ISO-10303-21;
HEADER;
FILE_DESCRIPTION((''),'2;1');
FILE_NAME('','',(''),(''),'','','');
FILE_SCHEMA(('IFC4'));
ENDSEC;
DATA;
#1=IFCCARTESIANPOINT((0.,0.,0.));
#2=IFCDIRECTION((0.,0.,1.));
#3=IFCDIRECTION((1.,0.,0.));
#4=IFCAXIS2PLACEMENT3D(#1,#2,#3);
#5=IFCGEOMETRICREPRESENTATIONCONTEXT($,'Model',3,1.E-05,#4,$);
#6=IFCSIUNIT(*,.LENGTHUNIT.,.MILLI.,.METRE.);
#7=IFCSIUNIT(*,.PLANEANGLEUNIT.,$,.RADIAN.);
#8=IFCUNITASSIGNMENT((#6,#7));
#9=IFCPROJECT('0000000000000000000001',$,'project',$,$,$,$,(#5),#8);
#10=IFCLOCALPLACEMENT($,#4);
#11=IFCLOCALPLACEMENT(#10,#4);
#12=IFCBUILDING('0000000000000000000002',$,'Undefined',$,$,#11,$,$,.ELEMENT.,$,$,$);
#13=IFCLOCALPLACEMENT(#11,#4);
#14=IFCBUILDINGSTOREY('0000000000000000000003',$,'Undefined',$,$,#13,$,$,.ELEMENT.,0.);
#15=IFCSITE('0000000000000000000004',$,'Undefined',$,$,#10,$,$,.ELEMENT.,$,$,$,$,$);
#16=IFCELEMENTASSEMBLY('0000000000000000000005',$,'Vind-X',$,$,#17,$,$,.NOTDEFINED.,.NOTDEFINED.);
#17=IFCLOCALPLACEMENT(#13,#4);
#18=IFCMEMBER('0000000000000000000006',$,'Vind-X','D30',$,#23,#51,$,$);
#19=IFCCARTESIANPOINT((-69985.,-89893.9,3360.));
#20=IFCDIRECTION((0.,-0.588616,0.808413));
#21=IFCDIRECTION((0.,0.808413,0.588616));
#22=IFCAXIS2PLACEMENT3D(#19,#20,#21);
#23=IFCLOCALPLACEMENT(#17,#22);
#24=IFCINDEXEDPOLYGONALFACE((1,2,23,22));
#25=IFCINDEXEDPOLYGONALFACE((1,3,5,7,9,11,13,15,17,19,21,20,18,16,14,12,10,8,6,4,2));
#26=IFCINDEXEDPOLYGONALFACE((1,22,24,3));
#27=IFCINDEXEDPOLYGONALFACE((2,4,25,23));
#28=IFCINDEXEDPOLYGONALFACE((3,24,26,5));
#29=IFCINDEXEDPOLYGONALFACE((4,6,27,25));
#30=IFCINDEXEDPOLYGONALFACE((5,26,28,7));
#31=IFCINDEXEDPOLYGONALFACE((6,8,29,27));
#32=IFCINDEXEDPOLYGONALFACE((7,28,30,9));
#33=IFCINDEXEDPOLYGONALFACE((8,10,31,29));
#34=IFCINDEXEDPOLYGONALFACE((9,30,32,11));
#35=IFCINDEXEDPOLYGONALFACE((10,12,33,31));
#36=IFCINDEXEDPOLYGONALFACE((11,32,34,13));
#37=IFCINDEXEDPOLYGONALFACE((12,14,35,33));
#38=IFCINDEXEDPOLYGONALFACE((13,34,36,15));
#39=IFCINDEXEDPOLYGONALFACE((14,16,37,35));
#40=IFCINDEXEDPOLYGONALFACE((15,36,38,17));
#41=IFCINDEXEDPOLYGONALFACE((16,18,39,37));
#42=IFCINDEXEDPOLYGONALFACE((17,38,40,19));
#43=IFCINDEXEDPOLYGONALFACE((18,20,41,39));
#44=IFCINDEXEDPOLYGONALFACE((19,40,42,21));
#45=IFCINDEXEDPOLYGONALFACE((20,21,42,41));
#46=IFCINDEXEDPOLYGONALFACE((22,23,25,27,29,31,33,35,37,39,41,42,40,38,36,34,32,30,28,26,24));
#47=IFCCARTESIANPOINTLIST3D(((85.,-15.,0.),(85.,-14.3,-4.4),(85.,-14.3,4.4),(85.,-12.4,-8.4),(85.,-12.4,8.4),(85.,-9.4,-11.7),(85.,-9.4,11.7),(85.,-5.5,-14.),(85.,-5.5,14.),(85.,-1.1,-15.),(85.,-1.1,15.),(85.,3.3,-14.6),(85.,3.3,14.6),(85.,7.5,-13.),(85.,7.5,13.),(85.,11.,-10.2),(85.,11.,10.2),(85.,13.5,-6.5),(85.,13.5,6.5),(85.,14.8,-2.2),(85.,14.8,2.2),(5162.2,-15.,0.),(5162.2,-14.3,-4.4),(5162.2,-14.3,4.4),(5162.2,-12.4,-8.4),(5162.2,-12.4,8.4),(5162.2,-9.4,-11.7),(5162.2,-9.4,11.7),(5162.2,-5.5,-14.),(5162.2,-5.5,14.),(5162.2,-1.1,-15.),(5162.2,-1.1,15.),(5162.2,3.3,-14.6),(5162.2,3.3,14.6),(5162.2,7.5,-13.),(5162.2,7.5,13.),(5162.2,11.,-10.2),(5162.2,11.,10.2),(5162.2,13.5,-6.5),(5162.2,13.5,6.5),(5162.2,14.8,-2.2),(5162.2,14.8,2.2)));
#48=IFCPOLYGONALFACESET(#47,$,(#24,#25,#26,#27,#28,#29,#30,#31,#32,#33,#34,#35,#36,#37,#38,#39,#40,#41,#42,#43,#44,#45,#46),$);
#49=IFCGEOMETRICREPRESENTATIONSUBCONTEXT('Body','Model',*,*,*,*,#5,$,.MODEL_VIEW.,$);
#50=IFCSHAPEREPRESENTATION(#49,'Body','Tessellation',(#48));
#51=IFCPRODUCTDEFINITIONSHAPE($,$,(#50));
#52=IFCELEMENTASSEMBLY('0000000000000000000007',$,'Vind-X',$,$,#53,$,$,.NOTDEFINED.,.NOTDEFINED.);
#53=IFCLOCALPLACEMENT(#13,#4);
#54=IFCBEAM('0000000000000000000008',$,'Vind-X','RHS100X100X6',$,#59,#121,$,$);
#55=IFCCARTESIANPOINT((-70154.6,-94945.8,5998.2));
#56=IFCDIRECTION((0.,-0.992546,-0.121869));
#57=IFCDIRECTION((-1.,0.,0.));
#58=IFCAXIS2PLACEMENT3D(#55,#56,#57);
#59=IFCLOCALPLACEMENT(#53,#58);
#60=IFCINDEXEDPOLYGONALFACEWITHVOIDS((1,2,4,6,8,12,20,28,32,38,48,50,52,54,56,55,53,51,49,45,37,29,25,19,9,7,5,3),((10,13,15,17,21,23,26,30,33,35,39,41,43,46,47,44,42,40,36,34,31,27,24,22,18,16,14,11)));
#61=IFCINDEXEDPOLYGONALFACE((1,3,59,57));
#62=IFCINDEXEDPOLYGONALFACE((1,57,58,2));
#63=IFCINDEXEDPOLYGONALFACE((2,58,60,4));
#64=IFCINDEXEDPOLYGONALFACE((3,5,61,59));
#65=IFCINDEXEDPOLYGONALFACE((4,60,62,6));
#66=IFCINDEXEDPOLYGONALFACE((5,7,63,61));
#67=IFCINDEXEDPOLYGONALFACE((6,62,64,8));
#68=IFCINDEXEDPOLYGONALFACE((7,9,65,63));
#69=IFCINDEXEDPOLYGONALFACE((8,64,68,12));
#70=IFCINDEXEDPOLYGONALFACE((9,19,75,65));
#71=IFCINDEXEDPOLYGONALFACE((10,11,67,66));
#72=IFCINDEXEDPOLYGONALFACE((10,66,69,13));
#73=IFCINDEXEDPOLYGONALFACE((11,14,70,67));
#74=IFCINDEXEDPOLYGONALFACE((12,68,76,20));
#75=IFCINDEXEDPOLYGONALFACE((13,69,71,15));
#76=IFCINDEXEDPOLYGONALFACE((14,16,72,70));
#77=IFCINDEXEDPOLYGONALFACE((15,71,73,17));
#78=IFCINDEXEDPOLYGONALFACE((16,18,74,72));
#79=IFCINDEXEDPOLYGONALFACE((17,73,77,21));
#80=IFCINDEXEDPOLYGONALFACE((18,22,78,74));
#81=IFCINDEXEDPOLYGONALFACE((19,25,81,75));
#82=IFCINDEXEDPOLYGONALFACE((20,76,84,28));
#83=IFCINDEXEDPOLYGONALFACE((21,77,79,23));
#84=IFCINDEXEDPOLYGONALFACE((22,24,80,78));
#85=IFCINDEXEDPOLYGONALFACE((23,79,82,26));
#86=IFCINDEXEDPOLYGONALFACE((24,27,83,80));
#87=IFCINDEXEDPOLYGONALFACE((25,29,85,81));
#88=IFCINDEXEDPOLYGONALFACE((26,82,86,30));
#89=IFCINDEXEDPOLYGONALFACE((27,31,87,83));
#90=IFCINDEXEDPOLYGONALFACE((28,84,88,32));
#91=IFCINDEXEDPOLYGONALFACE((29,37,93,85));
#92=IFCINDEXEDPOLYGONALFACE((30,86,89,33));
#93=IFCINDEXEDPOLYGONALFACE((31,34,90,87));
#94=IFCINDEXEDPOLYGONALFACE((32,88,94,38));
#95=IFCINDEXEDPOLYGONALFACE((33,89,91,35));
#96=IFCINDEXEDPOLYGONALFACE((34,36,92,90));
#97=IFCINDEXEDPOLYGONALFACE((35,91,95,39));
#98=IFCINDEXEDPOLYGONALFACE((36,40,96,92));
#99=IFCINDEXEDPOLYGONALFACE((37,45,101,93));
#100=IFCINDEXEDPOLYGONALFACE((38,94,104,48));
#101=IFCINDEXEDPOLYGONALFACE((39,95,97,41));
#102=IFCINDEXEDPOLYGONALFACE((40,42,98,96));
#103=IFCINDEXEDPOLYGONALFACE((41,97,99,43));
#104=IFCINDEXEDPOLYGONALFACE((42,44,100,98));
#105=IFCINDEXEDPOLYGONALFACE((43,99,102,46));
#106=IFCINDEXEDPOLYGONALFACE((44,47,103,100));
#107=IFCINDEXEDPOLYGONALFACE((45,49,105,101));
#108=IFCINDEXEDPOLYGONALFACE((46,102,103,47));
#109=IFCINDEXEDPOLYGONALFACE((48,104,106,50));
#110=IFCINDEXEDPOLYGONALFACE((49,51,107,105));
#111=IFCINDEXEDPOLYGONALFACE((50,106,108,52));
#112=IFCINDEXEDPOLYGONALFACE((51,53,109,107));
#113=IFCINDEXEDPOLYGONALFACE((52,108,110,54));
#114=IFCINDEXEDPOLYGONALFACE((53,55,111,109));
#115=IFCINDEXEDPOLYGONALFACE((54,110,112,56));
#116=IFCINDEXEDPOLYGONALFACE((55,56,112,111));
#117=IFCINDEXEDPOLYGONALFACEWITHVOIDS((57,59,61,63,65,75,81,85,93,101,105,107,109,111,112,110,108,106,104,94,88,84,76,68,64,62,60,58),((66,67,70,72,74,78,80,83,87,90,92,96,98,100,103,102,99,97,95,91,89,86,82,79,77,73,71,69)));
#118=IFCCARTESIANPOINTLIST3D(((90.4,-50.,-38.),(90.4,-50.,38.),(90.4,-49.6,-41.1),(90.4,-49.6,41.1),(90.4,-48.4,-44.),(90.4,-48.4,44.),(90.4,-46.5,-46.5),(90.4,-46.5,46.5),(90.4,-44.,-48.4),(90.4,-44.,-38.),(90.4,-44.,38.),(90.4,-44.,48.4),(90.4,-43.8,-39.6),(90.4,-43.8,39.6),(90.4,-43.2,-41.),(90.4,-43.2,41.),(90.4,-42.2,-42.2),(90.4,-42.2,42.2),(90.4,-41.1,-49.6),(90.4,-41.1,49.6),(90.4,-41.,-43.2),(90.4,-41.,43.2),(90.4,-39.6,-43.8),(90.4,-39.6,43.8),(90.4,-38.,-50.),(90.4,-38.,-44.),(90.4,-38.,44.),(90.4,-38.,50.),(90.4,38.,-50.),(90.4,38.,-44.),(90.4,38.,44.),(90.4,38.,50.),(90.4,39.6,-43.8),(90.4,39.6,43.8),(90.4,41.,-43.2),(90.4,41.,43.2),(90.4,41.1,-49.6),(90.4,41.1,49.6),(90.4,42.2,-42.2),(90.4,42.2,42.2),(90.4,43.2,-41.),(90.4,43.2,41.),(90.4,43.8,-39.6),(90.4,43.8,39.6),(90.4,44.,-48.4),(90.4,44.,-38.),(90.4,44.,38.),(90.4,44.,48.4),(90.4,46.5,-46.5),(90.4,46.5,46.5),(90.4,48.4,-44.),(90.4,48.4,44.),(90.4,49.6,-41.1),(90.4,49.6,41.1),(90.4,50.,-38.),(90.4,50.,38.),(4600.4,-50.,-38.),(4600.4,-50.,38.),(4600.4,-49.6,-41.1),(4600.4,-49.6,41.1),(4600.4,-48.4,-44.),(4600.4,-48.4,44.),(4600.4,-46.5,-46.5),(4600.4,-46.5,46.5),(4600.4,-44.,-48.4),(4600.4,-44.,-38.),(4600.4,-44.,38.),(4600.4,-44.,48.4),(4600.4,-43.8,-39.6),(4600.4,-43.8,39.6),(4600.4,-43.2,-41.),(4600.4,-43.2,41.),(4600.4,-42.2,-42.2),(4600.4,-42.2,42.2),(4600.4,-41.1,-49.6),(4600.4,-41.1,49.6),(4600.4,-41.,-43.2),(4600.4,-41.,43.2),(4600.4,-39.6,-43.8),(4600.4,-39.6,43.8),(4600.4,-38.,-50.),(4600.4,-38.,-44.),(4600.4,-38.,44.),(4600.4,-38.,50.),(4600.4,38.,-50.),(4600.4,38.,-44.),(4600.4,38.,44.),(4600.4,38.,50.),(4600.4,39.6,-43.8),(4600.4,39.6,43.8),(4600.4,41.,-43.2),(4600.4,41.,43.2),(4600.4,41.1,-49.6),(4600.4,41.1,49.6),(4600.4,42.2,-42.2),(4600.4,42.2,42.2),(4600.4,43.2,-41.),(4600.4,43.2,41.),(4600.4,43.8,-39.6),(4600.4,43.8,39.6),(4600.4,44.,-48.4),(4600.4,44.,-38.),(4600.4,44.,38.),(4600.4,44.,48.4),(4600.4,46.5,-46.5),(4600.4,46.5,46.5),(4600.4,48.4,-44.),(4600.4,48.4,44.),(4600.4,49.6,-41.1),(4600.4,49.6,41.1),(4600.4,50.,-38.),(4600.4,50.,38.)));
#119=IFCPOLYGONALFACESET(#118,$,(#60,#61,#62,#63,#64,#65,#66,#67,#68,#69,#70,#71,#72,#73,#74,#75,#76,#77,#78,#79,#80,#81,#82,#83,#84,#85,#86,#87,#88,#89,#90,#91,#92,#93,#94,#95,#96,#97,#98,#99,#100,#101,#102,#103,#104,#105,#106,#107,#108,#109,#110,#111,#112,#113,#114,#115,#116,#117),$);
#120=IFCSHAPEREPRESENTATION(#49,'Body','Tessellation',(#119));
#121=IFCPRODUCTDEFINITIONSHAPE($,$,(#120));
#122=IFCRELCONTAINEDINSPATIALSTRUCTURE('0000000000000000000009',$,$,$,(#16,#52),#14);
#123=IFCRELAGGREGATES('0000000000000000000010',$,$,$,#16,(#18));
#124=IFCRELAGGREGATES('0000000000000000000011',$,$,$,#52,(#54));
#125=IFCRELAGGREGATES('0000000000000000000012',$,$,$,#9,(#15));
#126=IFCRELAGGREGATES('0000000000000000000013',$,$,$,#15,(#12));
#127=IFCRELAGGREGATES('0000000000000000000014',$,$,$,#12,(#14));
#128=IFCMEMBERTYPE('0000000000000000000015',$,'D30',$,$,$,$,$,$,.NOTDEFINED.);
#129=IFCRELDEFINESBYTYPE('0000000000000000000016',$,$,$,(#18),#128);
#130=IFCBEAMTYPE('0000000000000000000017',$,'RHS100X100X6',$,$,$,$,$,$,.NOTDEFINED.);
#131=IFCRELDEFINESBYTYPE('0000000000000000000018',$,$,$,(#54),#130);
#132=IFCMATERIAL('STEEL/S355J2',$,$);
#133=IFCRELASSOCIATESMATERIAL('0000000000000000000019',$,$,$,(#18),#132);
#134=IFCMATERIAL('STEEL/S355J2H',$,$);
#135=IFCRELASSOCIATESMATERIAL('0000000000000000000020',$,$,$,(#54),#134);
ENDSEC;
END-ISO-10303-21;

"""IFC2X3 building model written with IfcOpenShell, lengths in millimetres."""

from ifc_helpers import new_model, si_unit, frame, origin_with_axes, origin_2d_with_axis, place, context, subcontext, project, spatial, hollow_rectangle, circle, extrude, clip, halfspace, material, type_object, element, aggregate, save


model = new_model("IFC2X3")

# Units and contexts
model_context = context("Model", 3, precision=1e-05, world=origin_with_axes())
body_context = subcontext(model_context, "Body", "Model", "MODEL_VIEW")
ifc_project = project(units=[si_unit("LENGTHUNIT", "METRE", prefix="MILLI"), si_unit("PLANEANGLEUNIT", "RADIAN")], contexts=[model_context])

# Site, building, storey
site_placement = place(None, origin_with_axes())
site = spatial("IfcSite", under=ifc_project, at=site_placement, Name="Undefined", CompositionType="ELEMENT")
building_placement = place(site_placement, origin_with_axes())
building = spatial("IfcBuilding", under=site, at=building_placement, Name="Undefined", CompositionType="ELEMENT")
storey_placement = place(building_placement, origin_with_axes())
storey = spatial("IfcBuildingStorey", under=building, at=storey_placement, Name="Undefined", CompositionType="ELEMENT", Elevation=0.0)

# Shared definitions
ifc_material_1 = material(Name="STEEL/S355J2H")

# Element assembly, member
assembly_1_placement = place(storey_placement, origin_with_axes())
assembly_1 = element("IfcElementAssembly", 1, at=assembly_1_placement, inside=storey, Name="Vind-X", AssemblyPlace="NOTDEFINED", PredefinedType="NOTDEFINED")
ifc_material_2 = material(Name="STEEL/S355J2")
member_type = type_object("IfcMemberType", Name="D30", PredefinedType="NOTDEFINED")
member_placement = place(assembly_1_placement, frame((-69985.0, -89893.9, 3360.0), z_axis=(0.0, -0.588616, 0.808413), x_axis=(0.0, 0.808413, 0.588616)))
member = element("IfcMember", 2, at=member_placement, type_object=member_type, material=ifc_material_2, Name="Vind-X", Description="D30", context=body_context, shape_type="Clipping", body=[
    clip(clip(extrude(circle(Radius=15.0, at=origin_2d_with_axis()), frame((5827.2, 0.0, 0.0), z_axis=(-1.0, 0.0, 0.0), x_axis=(0.0, -1.0, 0.0)), (0.0, 0.0, 1.0), 5827.2), halfspace(frame((5162.2, -6.0, 10.2), z_axis=(1.0, 0.0, 0.0), x_axis=(0.0, 1.0, 0.0)), False)), halfspace(frame((85.0, -6.0, 16.0), z_axis=(1.0, 0.0, 0.0), x_axis=(0.0, 1.0, 0.0)), True)),
])

# Element assembly, beam
assembly_2_placement = place(storey_placement, origin_with_axes())
assembly_2 = element("IfcElementAssembly", 3, at=assembly_2_placement, inside=storey, Name="Vind-X", AssemblyPlace="NOTDEFINED", PredefinedType="NOTDEFINED")
beam_type = type_object("IfcBeamType", Name="RHS100X100X6", PredefinedType="NOTDEFINED")
beam_placement = place(assembly_2_placement, frame((-70154.6, -94945.8, 5998.2), z_axis=(0.0, -0.992546, -0.121869), x_axis=(-1.0, 0.0, 0.0)))
beam = element("IfcBeam", 4, at=beam_placement, type_object=beam_type, material=ifc_material_1, Name="Vind-X", Description="RHS100X100X6", context=body_context, shape_type="Clipping", body=[
    clip(clip(extrude(hollow_rectangle(XDim=100.0, YDim=100.0, WallThickness=6.0, InnerFilletRadius=6.0, OuterFilletRadius=12.0, at=origin_2d_with_axis()), frame((4690.0, 0.0, 0.0), z_axis=(-1.0, 0.0, 0.0), x_axis=(0.0, -1.0, 0.0)), (0.0, 0.0, 1.0), 4690.0), halfspace(frame((4600.4, 22.5, 0.0), z_axis=(-1.0, 0.0, 0.0), x_axis=(0.0, 0.0, 1.0)), True)), halfspace(frame((90.4, 22.5, 0.0), z_axis=(1.0, 0.0, 0.0), x_axis=(0.0, 0.0, -1.0)), True)),
])

aggregate(assembly_1, [member])
aggregate(assembly_2, [beam])

save(model, "model.ifc")
